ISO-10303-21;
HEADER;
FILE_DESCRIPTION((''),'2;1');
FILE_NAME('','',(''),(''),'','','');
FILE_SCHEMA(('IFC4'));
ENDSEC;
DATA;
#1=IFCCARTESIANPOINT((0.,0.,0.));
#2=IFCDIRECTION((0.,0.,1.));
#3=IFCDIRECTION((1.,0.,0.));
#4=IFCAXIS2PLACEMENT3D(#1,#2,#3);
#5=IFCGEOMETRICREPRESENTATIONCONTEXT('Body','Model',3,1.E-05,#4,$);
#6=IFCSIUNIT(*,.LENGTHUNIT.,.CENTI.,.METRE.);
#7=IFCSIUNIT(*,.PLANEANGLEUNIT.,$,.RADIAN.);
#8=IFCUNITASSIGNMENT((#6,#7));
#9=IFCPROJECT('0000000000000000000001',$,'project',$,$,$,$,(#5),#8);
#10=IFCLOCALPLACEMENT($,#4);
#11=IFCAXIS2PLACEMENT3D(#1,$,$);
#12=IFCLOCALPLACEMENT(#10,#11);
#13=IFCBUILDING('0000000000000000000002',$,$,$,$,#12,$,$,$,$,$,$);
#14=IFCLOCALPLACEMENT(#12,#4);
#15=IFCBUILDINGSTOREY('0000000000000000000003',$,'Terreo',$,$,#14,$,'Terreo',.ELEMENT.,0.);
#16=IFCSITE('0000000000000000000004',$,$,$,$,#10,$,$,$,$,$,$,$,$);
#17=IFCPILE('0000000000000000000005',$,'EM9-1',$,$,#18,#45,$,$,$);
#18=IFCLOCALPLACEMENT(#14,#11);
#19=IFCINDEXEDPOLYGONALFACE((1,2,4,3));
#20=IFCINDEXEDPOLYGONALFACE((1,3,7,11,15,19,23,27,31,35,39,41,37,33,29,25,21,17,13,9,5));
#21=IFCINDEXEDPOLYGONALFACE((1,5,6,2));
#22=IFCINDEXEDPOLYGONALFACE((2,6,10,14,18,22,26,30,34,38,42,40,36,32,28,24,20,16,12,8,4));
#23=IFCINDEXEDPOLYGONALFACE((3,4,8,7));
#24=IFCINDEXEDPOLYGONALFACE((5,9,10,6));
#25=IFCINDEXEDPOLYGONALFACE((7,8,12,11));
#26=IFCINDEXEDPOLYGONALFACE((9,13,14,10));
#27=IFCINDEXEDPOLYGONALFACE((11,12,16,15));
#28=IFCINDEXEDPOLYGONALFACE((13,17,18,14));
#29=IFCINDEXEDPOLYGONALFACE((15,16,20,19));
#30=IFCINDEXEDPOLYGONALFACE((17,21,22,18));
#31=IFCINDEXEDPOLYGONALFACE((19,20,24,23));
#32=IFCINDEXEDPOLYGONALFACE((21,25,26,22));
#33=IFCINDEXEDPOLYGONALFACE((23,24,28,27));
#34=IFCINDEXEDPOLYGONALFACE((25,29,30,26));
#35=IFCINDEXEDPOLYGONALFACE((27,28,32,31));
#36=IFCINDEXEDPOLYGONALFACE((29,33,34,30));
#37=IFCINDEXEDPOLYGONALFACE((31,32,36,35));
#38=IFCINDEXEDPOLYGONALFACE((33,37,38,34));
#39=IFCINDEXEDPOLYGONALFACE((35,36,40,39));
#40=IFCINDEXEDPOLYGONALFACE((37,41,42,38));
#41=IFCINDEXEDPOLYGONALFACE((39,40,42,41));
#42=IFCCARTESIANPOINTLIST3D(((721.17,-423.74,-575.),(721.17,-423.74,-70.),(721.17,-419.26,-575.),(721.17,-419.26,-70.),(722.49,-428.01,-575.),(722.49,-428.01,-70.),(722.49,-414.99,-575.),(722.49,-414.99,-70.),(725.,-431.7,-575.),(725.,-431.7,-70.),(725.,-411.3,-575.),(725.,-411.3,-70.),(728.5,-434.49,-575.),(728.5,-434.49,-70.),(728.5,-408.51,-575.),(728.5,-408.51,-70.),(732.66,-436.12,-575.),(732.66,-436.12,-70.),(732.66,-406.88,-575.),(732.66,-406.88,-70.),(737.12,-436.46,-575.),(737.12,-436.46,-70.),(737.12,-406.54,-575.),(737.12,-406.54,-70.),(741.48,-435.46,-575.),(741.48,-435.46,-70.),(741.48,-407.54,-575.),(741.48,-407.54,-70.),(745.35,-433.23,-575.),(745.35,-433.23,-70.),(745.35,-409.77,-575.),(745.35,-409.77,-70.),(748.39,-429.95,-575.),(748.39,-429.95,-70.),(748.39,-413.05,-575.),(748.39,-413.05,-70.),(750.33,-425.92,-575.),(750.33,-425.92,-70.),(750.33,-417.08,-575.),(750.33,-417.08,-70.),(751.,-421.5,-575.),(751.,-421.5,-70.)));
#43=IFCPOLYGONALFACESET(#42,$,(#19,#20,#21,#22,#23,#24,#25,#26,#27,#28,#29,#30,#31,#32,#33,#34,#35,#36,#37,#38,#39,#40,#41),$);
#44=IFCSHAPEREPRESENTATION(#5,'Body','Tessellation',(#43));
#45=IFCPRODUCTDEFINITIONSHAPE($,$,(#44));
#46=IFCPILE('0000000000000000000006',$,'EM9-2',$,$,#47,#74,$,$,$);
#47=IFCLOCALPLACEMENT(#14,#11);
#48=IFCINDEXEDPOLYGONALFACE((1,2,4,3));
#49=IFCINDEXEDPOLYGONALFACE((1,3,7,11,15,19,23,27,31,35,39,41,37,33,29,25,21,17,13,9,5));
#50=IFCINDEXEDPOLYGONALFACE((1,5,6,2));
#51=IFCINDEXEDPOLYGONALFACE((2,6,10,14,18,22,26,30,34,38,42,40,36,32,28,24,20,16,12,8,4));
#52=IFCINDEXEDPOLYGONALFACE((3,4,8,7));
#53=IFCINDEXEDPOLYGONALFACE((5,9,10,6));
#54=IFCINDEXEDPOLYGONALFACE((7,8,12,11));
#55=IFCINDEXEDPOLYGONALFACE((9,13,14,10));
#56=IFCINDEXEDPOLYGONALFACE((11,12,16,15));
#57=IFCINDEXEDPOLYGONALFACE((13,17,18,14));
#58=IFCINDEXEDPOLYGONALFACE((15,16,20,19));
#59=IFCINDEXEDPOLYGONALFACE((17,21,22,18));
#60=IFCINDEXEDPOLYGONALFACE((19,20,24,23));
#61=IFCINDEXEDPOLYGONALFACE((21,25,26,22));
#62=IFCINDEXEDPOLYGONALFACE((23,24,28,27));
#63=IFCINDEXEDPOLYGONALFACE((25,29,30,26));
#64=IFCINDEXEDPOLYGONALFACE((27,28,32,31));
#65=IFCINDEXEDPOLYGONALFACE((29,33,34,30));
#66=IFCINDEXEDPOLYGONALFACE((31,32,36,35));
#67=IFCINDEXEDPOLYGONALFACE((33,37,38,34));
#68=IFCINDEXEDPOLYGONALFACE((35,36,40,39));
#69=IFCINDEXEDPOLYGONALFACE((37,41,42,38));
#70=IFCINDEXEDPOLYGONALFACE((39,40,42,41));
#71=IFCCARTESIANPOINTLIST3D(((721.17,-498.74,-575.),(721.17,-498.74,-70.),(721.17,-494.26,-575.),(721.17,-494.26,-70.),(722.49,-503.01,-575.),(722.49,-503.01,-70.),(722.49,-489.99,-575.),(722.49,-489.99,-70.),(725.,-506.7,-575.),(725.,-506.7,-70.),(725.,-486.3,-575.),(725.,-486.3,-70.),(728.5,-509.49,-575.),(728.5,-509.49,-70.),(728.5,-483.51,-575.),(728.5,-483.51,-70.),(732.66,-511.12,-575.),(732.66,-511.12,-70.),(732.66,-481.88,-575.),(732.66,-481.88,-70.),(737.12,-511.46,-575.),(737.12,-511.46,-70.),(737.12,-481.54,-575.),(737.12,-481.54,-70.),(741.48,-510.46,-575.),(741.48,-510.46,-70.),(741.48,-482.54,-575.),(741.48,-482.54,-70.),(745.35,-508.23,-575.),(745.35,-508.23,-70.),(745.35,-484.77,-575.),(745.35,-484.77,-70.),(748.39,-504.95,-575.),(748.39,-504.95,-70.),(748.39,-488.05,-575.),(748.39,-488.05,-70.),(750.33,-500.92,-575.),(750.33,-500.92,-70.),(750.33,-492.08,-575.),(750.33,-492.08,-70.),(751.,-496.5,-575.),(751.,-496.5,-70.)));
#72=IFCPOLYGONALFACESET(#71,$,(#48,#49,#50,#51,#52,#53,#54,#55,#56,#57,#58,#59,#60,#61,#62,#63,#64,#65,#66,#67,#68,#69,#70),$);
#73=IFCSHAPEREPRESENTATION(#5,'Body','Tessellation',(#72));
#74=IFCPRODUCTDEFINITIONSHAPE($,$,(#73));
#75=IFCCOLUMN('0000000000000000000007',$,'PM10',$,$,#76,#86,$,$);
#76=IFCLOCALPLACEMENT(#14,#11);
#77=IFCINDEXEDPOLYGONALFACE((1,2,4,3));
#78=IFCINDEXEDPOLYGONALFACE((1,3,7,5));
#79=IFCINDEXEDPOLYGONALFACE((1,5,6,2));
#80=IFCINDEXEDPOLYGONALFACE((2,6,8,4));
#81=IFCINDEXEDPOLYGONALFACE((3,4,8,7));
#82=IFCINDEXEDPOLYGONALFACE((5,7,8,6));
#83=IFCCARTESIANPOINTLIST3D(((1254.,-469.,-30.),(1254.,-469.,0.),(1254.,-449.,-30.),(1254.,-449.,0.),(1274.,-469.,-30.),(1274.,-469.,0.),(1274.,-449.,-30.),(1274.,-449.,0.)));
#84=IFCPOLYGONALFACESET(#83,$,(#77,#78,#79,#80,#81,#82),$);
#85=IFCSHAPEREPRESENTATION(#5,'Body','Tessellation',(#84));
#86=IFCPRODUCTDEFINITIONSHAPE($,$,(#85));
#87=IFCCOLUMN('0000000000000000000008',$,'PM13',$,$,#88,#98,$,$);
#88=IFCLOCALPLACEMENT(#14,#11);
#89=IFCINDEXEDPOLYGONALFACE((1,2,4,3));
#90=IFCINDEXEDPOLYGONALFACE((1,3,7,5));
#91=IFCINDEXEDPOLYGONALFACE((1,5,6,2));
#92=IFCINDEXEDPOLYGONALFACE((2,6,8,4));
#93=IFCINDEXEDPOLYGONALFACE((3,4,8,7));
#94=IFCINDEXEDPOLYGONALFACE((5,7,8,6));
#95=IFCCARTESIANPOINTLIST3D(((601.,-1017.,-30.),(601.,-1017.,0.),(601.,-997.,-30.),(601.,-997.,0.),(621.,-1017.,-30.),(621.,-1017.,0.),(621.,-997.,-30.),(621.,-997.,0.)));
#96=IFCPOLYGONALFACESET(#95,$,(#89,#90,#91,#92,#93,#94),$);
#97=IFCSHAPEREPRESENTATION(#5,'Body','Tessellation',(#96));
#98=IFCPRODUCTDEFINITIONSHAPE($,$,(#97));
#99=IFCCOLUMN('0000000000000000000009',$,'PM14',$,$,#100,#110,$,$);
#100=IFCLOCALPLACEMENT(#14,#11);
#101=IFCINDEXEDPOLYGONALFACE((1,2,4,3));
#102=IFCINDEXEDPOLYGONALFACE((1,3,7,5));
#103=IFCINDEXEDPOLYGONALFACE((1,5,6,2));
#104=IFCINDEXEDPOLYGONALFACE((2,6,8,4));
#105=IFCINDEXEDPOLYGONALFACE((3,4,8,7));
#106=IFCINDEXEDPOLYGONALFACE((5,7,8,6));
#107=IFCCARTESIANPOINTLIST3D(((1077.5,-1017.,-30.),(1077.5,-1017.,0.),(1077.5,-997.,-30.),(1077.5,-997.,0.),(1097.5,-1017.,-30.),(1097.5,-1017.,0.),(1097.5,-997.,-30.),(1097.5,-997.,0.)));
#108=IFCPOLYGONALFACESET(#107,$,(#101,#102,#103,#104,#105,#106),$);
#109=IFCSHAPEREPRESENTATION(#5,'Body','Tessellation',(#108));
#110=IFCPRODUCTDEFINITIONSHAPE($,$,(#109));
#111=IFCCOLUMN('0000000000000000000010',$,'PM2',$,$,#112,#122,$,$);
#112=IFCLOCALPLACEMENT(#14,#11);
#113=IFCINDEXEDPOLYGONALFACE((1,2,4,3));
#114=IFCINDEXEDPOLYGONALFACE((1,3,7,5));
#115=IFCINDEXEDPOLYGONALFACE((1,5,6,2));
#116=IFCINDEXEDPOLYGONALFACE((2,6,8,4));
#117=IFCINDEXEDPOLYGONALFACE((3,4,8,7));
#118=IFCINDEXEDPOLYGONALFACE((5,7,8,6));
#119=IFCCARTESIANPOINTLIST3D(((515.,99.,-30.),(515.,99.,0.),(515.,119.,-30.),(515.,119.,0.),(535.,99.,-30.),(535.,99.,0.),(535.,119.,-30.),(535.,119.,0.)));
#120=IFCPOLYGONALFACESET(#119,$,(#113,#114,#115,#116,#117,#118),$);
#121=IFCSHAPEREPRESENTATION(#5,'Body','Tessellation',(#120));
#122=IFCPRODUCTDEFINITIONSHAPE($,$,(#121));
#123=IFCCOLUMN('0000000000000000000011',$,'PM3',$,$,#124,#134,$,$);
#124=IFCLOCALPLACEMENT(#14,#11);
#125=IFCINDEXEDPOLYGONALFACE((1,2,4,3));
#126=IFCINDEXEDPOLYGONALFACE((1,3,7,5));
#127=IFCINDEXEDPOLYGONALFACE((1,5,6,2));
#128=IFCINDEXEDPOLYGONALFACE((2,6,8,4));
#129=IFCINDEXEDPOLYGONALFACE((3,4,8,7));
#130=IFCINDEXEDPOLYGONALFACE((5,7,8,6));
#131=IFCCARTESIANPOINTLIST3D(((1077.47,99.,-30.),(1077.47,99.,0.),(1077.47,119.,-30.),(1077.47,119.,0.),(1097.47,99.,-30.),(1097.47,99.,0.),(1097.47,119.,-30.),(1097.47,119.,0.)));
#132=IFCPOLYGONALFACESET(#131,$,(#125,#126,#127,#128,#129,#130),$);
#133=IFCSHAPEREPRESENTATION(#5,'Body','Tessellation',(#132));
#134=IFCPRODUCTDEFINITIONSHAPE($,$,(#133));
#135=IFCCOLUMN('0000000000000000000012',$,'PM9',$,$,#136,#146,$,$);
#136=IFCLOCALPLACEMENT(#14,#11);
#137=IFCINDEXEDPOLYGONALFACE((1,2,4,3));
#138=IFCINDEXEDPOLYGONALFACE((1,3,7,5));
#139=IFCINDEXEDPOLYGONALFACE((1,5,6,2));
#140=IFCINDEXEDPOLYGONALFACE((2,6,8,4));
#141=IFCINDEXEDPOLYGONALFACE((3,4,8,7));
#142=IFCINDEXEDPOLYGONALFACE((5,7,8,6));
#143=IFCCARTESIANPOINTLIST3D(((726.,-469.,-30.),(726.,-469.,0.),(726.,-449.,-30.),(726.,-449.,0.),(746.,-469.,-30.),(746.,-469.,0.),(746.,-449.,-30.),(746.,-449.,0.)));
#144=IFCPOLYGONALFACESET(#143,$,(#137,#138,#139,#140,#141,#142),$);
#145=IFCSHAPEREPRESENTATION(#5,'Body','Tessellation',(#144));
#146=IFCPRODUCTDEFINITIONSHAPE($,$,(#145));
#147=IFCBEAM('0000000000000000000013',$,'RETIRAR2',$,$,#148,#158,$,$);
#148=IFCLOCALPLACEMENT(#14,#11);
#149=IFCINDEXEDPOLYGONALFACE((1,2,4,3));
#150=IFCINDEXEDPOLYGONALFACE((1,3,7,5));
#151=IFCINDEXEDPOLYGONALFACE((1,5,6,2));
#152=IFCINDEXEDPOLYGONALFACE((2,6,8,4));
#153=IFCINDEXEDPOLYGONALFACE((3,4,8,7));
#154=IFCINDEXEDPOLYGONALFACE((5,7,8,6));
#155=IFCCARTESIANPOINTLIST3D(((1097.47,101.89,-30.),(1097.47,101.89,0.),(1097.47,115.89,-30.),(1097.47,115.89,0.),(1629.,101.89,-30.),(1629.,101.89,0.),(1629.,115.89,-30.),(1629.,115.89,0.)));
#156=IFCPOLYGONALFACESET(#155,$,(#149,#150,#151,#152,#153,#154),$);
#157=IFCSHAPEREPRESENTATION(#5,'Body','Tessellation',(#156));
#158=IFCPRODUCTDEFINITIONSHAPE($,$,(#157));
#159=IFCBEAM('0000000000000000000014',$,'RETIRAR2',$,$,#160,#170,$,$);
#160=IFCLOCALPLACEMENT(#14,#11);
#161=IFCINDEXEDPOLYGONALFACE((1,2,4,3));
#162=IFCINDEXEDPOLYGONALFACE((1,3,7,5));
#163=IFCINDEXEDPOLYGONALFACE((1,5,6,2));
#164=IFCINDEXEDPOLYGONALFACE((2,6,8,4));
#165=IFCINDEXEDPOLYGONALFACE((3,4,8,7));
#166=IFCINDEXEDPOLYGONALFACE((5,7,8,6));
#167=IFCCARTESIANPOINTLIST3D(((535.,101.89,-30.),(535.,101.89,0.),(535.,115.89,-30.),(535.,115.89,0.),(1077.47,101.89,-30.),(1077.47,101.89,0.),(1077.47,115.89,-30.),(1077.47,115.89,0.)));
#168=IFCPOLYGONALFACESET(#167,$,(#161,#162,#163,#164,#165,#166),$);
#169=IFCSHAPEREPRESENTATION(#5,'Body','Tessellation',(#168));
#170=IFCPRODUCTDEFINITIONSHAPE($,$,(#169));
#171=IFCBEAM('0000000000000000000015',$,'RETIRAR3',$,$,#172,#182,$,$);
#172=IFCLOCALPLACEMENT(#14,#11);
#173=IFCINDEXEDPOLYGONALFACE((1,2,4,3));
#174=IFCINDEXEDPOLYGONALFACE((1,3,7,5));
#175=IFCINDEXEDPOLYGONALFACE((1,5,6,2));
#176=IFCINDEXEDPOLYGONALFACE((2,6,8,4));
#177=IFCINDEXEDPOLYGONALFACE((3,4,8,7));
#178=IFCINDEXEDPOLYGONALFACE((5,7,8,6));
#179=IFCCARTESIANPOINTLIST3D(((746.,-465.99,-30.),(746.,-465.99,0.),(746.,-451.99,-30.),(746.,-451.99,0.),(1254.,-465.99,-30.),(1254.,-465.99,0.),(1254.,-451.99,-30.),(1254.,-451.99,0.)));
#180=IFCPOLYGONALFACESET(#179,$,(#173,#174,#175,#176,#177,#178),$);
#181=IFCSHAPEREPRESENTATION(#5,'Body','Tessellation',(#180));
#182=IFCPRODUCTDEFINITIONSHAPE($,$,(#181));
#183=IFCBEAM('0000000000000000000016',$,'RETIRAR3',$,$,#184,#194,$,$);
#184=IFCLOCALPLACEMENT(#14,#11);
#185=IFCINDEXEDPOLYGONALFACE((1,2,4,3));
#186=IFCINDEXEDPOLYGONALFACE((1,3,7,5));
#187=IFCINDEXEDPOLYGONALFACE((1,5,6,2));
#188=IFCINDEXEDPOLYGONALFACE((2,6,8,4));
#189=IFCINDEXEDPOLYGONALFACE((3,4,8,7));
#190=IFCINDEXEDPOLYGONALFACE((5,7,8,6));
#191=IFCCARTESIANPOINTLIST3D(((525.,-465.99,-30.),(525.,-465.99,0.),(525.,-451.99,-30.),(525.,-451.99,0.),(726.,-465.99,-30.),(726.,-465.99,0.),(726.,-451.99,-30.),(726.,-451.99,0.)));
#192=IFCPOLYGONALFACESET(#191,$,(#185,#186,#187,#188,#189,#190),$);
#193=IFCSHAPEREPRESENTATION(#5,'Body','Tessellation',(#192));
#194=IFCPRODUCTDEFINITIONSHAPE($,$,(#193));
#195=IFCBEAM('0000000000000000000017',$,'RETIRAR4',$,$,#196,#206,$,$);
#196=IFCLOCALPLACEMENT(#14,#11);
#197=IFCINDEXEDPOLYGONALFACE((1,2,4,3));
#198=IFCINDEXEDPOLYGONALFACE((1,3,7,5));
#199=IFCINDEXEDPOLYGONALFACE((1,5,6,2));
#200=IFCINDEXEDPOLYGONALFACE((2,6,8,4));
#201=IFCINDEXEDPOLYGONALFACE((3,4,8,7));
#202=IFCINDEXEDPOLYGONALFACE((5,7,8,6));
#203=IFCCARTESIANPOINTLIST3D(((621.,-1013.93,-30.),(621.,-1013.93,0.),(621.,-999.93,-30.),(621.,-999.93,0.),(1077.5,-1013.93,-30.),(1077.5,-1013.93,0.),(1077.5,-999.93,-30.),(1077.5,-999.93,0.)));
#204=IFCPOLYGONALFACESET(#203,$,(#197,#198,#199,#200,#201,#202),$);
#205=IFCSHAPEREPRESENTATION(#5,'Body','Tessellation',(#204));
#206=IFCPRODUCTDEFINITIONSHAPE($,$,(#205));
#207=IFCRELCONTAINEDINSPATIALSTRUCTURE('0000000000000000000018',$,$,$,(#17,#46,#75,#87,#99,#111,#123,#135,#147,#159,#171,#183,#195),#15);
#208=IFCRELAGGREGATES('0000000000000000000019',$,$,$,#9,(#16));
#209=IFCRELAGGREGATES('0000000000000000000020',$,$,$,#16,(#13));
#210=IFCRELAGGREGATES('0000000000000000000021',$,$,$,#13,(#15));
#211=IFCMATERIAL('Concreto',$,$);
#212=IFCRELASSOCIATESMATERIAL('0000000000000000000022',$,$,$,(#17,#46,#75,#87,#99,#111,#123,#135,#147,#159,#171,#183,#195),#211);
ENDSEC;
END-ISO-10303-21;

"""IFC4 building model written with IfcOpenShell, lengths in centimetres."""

from ifc_helpers import new_model, si_unit, frame, origin, origin_with_axes, origin_2d_with_axis, place, context, project, spatial, rectangle, circle, extrude, material, element, save


model = new_model("IFC4")

# Units and contexts
model_context = context("Model", 3, precision=1e-05, world=origin_with_axes(), identifier="Body")
ifc_project = project(units=[si_unit("LENGTHUNIT", "METRE", prefix="CENTI"), si_unit("PLANEANGLEUNIT", "RADIAN")], contexts=[model_context])

# Site, building, storey
site_placement = place(None, origin_with_axes())
site = spatial("IfcSite", under=ifc_project, at=site_placement)
building_placement = place(site_placement, origin())
building = spatial("IfcBuilding", under=site, at=building_placement)
storey_placement = place(building_placement, origin_with_axes())
storey = spatial("IfcBuildingStorey", under=building, at=storey_placement, Name="Terreo", LongName="Terreo", CompositionType="ELEMENT", Elevation=0.0)

# Piles
ifc_material = material(Name="Concreto")
for number, where, z_axis, x_axis, name in (
    (1, (736.0, -421.5, -70.0), (0.0, 0.0, 1.0), (1.0, 0.0, 0.0), "EM9-1"),
    (2, (736.0, -496.5, -70.0), (0.0, 0.0, 1.0), (1.0, 0.0, 0.0), "EM9-2"),
):
    element("IfcPile", number, at=place(storey_placement, frame(where, z_axis=z_axis, x_axis=x_axis)), inside=storey, material=ifc_material, Name=name, context=model_context, shape_type="SweptSolid", body=[
        extrude(circle(Radius=15.0, at=origin_2d_with_axis()), frame((0.0, 0.0, -505.0), z_axis=(0.0, 0.0, 1.0), x_axis=(1.0, 0.0, 0.0)), (0.0, 0.0, 1.0), 505.0),
    ])

# Columns
for number, where, z_axis, x_axis, name in (
    (3, (1264.0, -459.0, 0.0), (0.0, 0.0, 1.0), (1.0, 0.0, 0.0), "PM10"),
    (4, (611.0, -1007.0, 0.0), (0.0, 0.0, 1.0), (1.0, 0.0, 0.0), "PM13"),
    (5, (1087.5, -1007.0, 0.0), (0.0, 0.0, 1.0), (1.0, 0.0, 0.0), "PM14"),
):
    element("IfcColumn", number, at=place(storey_placement, frame(where, z_axis=z_axis, x_axis=x_axis)), inside=storey, material=ifc_material, Name=name, context=model_context, shape_type="SolidModel", body=[
        extrude(rectangle(XDim=20.0, YDim=20.0, at=origin_2d_with_axis()), frame((0.0, 0.0, -30.0), z_axis=(0.0, 0.0, 1.0), x_axis=(0.0, 1.0, 0.0)), (0.0, 0.0, 1.0), 30.0),
    ])
column_placement = place(storey_placement, frame((525.0, 109.0, 0.0), z_axis=(0.0, 0.0, 1.0), x_axis=(1.0, 0.0, 0.0)))
element("IfcColumn", 6, at=column_placement, inside=storey, material=ifc_material, Name="PM2", context=model_context, shape_type="SolidModel", body=[
    extrude(rectangle(XDim=20.0, YDim=20.0, at=origin_2d_with_axis()), frame((0.0, 0.0, -30.0), z_axis=(0.0, 0.0, 1.0), x_axis=(1.0, 0.0, 0.0)), (0.0, 0.0, 1.0), 30.0),
])
for number, where, z_axis, x_axis, name in (
    (7, (1087.47, 109.0, 0.0), (0.0, 0.0, 1.0), (1.0, 0.0, 0.0), "PM3"),
    (8, (736.0, -459.0, 0.0), (0.0, 0.0, 1.0), (1.0, 0.0, 0.0), "PM9"),
):
    element("IfcColumn", number, at=place(storey_placement, frame(where, z_axis=z_axis, x_axis=x_axis)), inside=storey, material=ifc_material, Name=name, context=model_context, shape_type="SolidModel", body=[
        extrude(rectangle(XDim=20.0, YDim=20.0, at=origin_2d_with_axis()), frame((0.0, 0.0, -30.0), z_axis=(0.0, 0.0, 1.0), x_axis=(0.0, 1.0, 0.0)), (0.0, 0.0, 1.0), 30.0),
    ])

# Beams
beam_1_placement = place(storey_placement, frame((1363.23, 108.89, 0.0), z_axis=(0.0, 0.0, 1.0), x_axis=(1.0, 0.0, 0.0)))
element("IfcBeam", 9, at=beam_1_placement, inside=storey, material=ifc_material, Name="RETIRAR2", context=model_context, shape_type="SolidModel", body=[
    extrude(rectangle(XDim=14.0, YDim=30.0, at=origin_2d_with_axis()), frame((-265.76, 0.0, -15.0), z_axis=(1.0, 0.0, 0.0), x_axis=(0.0, 1.0, 0.0)), (0.0, 0.0, 1.0), 531.53),
])
beam_2_placement = place(storey_placement, frame((806.24, 108.89, 0.0), z_axis=(0.0, 0.0, 1.0), x_axis=(1.0, 0.0, 0.0)))
element("IfcBeam", 10, at=beam_2_placement, inside=storey, material=ifc_material, Name="RETIRAR2", context=model_context, shape_type="SolidModel", body=[
    extrude(rectangle(XDim=14.0, YDim=30.0, at=origin_2d_with_axis()), frame((-271.24, 0.0, -15.0), z_axis=(1.0, 0.0, 0.0), x_axis=(0.0, 1.0, 0.0)), (0.0, 0.0, 1.0), 542.47),
])
beam_3_placement = place(storey_placement, frame((1000.0, -458.99, 0.0), z_axis=(0.0, 0.0, 1.0), x_axis=(1.0, 0.0, 0.0)))
element("IfcBeam", 11, at=beam_3_placement, inside=storey, material=ifc_material, Name="RETIRAR3", context=model_context, shape_type="SolidModel", body=[
    extrude(rectangle(XDim=14.0, YDim=30.0, at=origin_2d_with_axis()), frame((-254.0, 0.0, -15.0), z_axis=(1.0, 0.0, 0.0), x_axis=(0.0, 1.0, 0.0)), (0.0, 0.0, 1.0), 508.0),
])
beam_4_placement = place(storey_placement, frame((625.5, -458.99, 0.0), z_axis=(0.0, 0.0, 1.0), x_axis=(1.0, 0.0, 0.0)))
element("IfcBeam", 12, at=beam_4_placement, inside=storey, material=ifc_material, Name="RETIRAR3", context=model_context, shape_type="SolidModel", body=[
    extrude(rectangle(XDim=14.0, YDim=30.0, at=origin_2d_with_axis()), frame((-100.5, 0.0, -15.0), z_axis=(1.0, 0.0, 0.0), x_axis=(0.0, -1.0, 0.0)), (0.0, 0.0, 1.0), 201.0),
])
beam_5_placement = place(storey_placement, frame((849.25, -1006.93, 0.0), z_axis=(0.0, 0.0, 1.0), x_axis=(1.0, 0.0, 0.0)))
element("IfcBeam", 13, at=beam_5_placement, inside=storey, material=ifc_material, Name="RETIRAR4", context=model_context, shape_type="SolidModel", body=[
    extrude(rectangle(XDim=14.0, YDim=30.0, at=origin_2d_with_axis()), frame((-228.25, 0.0, -15.0), z_axis=(1.0, 0.0, 0.0), x_axis=(0.0, -1.0, 0.0)), (0.0, 0.0, 1.0), 456.5),
])

save(model, "model.ifc")
